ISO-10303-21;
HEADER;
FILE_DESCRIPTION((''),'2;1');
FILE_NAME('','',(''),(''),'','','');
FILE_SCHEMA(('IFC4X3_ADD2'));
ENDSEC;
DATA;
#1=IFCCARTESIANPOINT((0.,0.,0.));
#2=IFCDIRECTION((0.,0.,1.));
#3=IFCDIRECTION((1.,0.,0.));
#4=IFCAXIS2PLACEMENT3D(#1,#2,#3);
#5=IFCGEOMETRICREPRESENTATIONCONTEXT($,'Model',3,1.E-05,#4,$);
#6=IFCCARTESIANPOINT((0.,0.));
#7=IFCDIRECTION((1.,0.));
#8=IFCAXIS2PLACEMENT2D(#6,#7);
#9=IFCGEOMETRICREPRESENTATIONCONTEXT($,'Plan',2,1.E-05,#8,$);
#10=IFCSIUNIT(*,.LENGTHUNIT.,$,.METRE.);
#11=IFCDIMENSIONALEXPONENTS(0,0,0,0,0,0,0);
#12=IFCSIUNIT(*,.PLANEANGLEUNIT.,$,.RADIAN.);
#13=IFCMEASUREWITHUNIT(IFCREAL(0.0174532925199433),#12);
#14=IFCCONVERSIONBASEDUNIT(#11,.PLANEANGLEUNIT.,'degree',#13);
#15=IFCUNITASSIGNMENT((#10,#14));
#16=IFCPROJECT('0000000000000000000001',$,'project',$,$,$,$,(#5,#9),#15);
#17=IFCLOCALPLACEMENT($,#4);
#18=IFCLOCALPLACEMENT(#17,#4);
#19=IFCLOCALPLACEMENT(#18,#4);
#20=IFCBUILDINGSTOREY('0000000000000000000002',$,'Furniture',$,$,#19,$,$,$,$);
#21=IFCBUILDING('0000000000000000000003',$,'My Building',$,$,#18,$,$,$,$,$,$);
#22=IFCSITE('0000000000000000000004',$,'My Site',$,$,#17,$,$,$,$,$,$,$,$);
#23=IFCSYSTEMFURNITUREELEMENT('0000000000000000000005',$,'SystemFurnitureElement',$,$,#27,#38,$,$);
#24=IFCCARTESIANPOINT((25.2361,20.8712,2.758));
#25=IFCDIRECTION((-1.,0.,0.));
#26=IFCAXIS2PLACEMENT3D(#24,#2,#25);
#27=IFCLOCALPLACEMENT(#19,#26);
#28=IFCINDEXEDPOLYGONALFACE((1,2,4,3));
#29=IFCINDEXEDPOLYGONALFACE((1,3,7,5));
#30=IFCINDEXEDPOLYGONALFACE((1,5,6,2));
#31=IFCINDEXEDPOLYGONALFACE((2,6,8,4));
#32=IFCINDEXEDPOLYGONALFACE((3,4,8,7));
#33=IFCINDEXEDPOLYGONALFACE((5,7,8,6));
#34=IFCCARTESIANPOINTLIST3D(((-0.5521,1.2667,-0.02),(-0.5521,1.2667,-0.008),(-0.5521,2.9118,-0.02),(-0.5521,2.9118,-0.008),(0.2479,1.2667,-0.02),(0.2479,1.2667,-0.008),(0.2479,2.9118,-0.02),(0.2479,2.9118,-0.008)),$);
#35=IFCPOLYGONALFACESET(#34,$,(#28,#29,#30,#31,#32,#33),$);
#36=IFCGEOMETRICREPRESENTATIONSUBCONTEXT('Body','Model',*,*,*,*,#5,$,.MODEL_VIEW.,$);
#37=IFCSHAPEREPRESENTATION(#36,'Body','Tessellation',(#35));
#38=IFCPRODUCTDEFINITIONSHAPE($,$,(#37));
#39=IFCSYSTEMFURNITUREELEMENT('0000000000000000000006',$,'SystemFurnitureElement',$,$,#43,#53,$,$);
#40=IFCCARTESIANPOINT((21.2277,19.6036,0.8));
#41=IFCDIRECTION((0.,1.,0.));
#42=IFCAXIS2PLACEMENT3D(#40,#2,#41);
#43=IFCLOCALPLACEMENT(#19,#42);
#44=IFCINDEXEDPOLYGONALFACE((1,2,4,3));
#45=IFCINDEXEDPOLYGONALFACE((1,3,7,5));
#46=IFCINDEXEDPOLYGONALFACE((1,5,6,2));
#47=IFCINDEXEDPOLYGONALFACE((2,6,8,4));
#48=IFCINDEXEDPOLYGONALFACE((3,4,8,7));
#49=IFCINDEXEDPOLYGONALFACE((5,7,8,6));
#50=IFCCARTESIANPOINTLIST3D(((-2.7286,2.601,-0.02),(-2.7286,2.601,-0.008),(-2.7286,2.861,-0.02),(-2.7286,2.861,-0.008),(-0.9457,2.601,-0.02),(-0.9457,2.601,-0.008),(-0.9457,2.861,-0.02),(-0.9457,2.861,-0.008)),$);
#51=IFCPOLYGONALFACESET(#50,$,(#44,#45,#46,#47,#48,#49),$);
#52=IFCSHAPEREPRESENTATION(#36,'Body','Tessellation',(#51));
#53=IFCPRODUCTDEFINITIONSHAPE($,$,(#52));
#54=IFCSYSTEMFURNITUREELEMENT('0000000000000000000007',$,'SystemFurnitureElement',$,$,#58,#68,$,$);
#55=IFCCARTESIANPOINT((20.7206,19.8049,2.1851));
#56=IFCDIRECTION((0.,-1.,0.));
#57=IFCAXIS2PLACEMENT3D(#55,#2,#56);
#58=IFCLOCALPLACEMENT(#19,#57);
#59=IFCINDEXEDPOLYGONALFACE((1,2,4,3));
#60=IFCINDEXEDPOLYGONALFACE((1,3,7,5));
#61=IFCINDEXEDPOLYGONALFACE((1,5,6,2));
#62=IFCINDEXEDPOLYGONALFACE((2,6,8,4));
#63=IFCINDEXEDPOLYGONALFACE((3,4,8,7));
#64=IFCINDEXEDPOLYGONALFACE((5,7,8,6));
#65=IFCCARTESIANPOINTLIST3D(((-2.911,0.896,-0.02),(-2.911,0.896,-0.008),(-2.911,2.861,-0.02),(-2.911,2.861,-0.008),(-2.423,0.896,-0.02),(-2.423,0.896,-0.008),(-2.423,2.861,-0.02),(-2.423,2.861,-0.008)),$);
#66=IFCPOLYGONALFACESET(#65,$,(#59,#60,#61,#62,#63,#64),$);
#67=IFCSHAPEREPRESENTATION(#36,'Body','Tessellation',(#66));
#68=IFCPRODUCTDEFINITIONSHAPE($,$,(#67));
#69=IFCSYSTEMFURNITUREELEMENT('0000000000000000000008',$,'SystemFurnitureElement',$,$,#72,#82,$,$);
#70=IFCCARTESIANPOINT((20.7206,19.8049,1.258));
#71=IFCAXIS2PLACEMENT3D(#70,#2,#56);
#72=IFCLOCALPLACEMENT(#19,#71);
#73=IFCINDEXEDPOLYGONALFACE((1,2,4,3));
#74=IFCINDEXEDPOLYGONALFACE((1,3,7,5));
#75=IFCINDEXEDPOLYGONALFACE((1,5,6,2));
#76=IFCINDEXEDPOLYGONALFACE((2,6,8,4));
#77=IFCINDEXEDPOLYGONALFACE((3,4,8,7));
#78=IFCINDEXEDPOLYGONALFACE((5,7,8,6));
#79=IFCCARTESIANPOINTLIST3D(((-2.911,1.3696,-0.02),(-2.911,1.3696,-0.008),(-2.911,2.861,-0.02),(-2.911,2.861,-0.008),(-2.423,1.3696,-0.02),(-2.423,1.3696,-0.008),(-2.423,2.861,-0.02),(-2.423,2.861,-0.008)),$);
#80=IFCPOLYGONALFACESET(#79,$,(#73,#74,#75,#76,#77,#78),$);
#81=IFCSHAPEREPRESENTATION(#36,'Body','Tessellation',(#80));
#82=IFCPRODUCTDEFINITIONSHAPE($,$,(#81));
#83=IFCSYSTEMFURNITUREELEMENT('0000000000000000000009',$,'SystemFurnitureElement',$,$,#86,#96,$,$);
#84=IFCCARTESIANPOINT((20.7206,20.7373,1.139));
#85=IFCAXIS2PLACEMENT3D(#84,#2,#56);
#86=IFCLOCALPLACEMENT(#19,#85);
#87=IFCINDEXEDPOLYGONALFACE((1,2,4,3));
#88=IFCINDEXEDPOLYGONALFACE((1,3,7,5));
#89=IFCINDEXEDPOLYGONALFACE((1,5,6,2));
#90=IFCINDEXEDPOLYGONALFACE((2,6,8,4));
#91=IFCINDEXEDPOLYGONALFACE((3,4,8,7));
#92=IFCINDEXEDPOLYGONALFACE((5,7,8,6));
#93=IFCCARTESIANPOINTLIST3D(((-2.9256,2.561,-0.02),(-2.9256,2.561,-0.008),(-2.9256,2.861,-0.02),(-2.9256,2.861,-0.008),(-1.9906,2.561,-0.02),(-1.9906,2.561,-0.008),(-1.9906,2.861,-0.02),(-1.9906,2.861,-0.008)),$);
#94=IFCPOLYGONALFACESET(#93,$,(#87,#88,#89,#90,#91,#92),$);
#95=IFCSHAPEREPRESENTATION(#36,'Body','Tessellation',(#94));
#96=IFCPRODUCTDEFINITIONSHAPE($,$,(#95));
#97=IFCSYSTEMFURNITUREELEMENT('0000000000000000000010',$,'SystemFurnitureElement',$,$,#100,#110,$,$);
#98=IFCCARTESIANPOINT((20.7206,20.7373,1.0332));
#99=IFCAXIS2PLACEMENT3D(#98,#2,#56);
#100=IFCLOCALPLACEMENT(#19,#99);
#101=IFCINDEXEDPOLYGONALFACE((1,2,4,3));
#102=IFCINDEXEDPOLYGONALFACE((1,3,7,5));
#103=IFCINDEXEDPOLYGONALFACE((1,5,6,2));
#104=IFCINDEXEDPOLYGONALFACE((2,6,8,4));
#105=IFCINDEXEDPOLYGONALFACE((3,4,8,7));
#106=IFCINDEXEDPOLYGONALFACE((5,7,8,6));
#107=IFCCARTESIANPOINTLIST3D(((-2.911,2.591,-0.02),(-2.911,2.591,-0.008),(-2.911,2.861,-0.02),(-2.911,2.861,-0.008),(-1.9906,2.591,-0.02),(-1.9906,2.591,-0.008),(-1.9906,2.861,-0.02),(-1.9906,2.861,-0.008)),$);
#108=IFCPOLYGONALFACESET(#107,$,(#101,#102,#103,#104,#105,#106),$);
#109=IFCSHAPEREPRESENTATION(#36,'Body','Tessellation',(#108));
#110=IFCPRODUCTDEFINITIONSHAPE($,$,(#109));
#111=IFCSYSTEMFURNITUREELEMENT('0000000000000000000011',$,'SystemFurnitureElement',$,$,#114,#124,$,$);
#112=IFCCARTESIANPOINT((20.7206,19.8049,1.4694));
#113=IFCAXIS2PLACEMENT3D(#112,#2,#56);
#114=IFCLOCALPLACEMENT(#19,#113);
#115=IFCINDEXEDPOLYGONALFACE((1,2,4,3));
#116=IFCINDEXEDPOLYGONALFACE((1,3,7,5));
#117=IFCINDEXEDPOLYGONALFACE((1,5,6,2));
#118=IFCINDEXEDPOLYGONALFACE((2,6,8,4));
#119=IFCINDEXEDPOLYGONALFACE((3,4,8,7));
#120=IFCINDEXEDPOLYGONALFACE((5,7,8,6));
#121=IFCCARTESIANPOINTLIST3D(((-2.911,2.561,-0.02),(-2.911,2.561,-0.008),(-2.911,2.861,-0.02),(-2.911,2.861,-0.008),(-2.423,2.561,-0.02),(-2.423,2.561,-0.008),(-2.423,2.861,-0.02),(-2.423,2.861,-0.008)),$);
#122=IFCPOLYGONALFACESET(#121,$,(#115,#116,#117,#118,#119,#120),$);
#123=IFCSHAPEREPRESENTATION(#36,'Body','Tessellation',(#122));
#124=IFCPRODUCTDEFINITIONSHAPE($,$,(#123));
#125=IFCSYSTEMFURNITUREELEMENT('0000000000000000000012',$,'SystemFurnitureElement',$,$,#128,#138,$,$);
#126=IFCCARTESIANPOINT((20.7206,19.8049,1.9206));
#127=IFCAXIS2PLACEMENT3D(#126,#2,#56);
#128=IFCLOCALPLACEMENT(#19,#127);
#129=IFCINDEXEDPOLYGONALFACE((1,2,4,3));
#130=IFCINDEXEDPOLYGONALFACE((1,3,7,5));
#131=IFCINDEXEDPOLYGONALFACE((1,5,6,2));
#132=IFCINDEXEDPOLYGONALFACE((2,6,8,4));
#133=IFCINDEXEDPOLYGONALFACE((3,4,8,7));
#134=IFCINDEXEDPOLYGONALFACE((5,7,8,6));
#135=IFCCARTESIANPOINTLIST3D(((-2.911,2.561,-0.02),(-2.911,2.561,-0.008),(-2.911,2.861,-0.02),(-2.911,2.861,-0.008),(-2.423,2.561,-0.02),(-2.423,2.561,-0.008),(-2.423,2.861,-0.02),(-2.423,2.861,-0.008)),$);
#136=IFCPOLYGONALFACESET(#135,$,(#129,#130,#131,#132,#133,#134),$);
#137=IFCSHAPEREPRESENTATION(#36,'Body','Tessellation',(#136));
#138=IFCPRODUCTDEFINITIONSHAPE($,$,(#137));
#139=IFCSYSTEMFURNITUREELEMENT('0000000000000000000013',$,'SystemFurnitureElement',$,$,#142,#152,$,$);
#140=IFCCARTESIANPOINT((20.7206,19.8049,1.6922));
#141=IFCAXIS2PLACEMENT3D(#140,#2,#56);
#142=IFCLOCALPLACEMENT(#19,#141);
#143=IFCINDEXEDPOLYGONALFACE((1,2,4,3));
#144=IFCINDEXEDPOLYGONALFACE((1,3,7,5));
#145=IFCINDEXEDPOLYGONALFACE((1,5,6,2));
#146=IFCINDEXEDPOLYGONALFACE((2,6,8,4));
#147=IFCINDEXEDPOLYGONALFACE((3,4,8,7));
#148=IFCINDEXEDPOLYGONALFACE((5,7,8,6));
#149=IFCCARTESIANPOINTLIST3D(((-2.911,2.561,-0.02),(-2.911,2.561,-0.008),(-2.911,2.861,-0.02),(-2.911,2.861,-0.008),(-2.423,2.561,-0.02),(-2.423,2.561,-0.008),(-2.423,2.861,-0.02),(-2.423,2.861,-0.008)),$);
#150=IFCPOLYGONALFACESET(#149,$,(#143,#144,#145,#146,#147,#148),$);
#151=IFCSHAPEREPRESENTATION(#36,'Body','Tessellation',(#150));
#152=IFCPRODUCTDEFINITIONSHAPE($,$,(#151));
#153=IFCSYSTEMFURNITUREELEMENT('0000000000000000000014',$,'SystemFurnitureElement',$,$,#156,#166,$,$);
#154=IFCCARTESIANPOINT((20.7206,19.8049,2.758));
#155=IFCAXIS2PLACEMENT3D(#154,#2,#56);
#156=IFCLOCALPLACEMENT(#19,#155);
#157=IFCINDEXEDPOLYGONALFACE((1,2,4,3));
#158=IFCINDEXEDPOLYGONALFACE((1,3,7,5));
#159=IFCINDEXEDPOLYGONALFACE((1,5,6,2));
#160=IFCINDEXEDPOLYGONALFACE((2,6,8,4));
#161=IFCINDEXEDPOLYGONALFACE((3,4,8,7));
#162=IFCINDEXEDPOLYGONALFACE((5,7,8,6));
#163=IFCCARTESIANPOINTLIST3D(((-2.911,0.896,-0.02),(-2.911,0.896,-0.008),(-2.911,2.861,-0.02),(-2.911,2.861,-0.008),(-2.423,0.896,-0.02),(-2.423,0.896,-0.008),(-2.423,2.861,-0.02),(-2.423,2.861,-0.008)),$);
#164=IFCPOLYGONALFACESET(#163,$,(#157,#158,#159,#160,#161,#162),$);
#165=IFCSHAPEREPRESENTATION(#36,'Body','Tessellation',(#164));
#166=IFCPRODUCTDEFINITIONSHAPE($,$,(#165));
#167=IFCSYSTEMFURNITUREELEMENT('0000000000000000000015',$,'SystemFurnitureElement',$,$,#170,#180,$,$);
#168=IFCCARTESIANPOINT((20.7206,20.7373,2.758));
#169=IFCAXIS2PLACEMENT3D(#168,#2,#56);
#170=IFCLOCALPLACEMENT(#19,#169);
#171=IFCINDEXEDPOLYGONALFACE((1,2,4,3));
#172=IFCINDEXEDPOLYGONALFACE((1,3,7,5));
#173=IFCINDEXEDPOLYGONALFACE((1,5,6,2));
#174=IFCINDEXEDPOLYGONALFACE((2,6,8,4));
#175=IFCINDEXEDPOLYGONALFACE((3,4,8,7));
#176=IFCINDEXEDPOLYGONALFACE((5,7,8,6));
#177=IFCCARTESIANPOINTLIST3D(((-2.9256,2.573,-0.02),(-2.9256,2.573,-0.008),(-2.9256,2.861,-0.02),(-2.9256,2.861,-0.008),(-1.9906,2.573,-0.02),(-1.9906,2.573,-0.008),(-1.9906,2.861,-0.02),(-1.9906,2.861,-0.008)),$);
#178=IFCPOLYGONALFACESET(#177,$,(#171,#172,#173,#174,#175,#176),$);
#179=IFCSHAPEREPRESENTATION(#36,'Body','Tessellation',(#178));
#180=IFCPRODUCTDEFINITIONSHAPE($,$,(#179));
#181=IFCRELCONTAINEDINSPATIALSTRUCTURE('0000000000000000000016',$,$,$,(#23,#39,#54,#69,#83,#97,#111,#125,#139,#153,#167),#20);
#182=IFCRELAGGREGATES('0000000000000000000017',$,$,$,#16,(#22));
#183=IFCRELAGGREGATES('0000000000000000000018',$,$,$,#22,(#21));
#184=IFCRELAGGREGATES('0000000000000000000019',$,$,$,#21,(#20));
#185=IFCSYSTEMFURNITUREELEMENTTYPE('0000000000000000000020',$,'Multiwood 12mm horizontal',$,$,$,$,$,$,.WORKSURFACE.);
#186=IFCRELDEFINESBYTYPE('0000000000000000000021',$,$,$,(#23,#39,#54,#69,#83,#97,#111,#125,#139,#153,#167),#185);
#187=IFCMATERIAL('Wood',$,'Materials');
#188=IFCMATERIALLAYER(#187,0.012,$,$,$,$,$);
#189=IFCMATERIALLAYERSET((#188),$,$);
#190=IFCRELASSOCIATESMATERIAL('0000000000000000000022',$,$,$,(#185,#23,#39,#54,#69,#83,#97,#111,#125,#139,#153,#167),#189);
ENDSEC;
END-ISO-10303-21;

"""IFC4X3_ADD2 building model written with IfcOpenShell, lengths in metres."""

from ifc_helpers import new_model, entity, si_unit, converted_unit, frame, origin_with_axes, origin_2d_with_axis, place, context, subcontext, project, spatial, indexed_curve, outline, extrude, material, layer, layer_set, layer_usage, type_object, element, save


model = new_model("IFC4X3_ADD2")

# Units and contexts
model_context = context("Model", 3, precision=1e-05, world=origin_with_axes())
plan_context = context("Plan", 2, precision=1e-05, world=origin_2d_with_axis())
body_context = subcontext(model_context, "Body", "Model", "MODEL_VIEW")
ifc_project = project(units=[si_unit("LENGTHUNIT", "METRE"), converted_unit("PLANEANGLEUNIT", "degree", entity("IfcReal", 0.0174532925199433), si_unit("PLANEANGLEUNIT", "RADIAN"), dimensions=[0, 0, 0, 0, 0, 0, 0])], contexts=[model_context, plan_context])

# Site, building, storey
site_placement = place(None, origin_with_axes())
site = spatial("IfcSite", under=ifc_project, at=site_placement, Name="My Site")
building_placement = place(site_placement, origin_with_axes())
building = spatial("IfcBuilding", under=site, at=building_placement, Name="My Building")
storey_placement = place(building_placement, origin_with_axes())
storey = spatial("IfcBuildingStorey", under=building, at=storey_placement, Name="Furniture")

# System furniture elements
ifc_material = material(Name="Wood", Category="Materials")
ifc_layer_1 = layer(ifc_material, 0.012)
ifc_layer_set_1 = layer_set([ifc_layer_1])
system_furniture_element_type_1 = type_object("IfcSystemFurnitureElementType", Name="Multiwood 12mm horizontal", PredefinedType="WORKSURFACE", material=ifc_layer_set_1)
ifc_layer_usage_1 = layer_usage(ifc_layer_set_1, "AXIS3", "POSITIVE", -0.02)
system_furniture_element_1_placement = place(storey_placement, frame((25.2361, 20.8712, 2.758), z_axis=(0.0, 0.0, 1.0), x_axis=(-1.0, 0.0, 0.0)))
element("IfcSystemFurnitureElement", 1, at=system_furniture_element_1_placement, inside=storey, type_object=system_furniture_element_type_1, material=ifc_layer_usage_1, Name="SystemFurnitureElement", context=body_context, shape_type="SweptSolid", body=[
    extrude(outline(indexed_curve([(-0.5521, 2.9118), (0.2479, 2.9118), (0.2479, 1.2667), (-0.5521, 1.2667), (-0.5521, 2.9118)])), frame((0.0, 0.0, -0.02), z_axis=(0.0, 0.0, 1.0), x_axis=(1.0, 0.0, 0.0)), (0.0, 0.0, 1.0), 0.012),
])
ifc_layer_usage_2 = layer_usage(ifc_layer_set_1, "AXIS3", "POSITIVE", -0.02)
system_furniture_element_2_placement = place(storey_placement, frame((21.2277, 19.6036, 0.8), z_axis=(0.0, 0.0, 1.0), x_axis=(0.0, 1.0, 0.0)))
element("IfcSystemFurnitureElement", 2, at=system_furniture_element_2_placement, inside=storey, type_object=system_furniture_element_type_1, material=ifc_layer_usage_2, Name="SystemFurnitureElement", context=body_context, shape_type="SweptSolid", body=[
    extrude(outline(indexed_curve([(-0.9457, 2.861), (-0.9457, 2.601), (-2.7286, 2.601), (-2.7286, 2.861), (-0.9457, 2.861)])), frame((0.0, 0.0, -0.02), z_axis=(0.0, 0.0, 1.0), x_axis=(1.0, 0.0, 0.0)), (0.0, 0.0, 1.0), 0.012),
])
ifc_layer_usage_3 = layer_usage(ifc_layer_set_1, "AXIS3", "POSITIVE", -0.02)
system_furniture_element_3_placement = place(storey_placement, frame((20.7206, 19.8049, 2.1851), z_axis=(0.0, 0.0, 1.0), x_axis=(0.0, -1.0, 0.0)))
element("IfcSystemFurnitureElement", 3, at=system_furniture_element_3_placement, inside=storey, type_object=system_furniture_element_type_1, material=ifc_layer_usage_3, Name="SystemFurnitureElement", context=body_context, shape_type="SweptSolid", body=[
    extrude(outline(indexed_curve([(-2.911, 2.861), (-2.911, 0.896), (-2.423, 0.896), (-2.423, 2.861), (-2.911, 2.861)])), frame((0.0, 0.0, -0.02), z_axis=(0.0, 0.0, 1.0), x_axis=(1.0, 0.0, 0.0)), (0.0, 0.0, 1.0), 0.012),
])
ifc_layer_usage_4 = layer_usage(ifc_layer_set_1, "AXIS3", "POSITIVE", -0.02)
system_furniture_element_4_placement = place(storey_placement, frame((20.7206, 19.8049, 1.258), z_axis=(0.0, 0.0, 1.0), x_axis=(0.0, -1.0, 0.0)))
element("IfcSystemFurnitureElement", 4, at=system_furniture_element_4_placement, inside=storey, type_object=system_furniture_element_type_1, material=ifc_layer_usage_4, Name="SystemFurnitureElement", context=body_context, shape_type="SweptSolid", body=[
    extrude(outline(indexed_curve([(-2.423, 2.861), (-2.423, 1.3696), (-2.911, 1.3696), (-2.911, 2.861), (-2.423, 2.861)])), frame((0.0, 0.0, -0.02), z_axis=(0.0, 0.0, 1.0), x_axis=(1.0, 0.0, 0.0)), (0.0, 0.0, 1.0), 0.012),
])
ifc_layer_usage_5 = layer_usage(ifc_layer_set_1, "AXIS3", "POSITIVE", -0.02)
system_furniture_element_5_placement = place(storey_placement, frame((20.7206, 20.7373, 1.139), z_axis=(0.0, 0.0, 1.0), x_axis=(0.0, -1.0, 0.0)))
element("IfcSystemFurnitureElement", 5, at=system_furniture_element_5_placement, inside=storey, type_object=system_furniture_element_type_1, material=ifc_layer_usage_5, Name="SystemFurnitureElement", context=body_context, shape_type="SweptSolid", body=[
    extrude(outline(indexed_curve([(-2.9256, 2.861), (-2.9256, 2.561), (-1.9906, 2.561), (-1.9906, 2.861), (-2.9256, 2.861)])), frame((0.0, 0.0, -0.02), z_axis=(0.0, 0.0, 1.0), x_axis=(1.0, 0.0, 0.0)), (0.0, 0.0, 1.0), 0.012),
])
ifc_layer_usage_6 = layer_usage(ifc_layer_set_1, "AXIS3", "POSITIVE", -0.02)
system_furniture_element_6_placement = place(storey_placement, frame((20.7206, 20.7373, 1.0332), z_axis=(0.0, 0.0, 1.0), x_axis=(0.0, -1.0, 0.0)))
element("IfcSystemFurnitureElement", 6, at=system_furniture_element_6_placement, inside=storey, type_object=system_furniture_element_type_1, material=ifc_layer_usage_6, Name="SystemFurnitureElement", context=body_context, shape_type="SweptSolid", body=[
    extrude(outline(indexed_curve([(-2.911, 2.861), (-2.911, 2.591), (-1.9906, 2.591), (-1.9906, 2.861), (-2.911, 2.861)])), frame((0.0, 0.0, -0.02), z_axis=(0.0, 0.0, 1.0), x_axis=(1.0, 0.0, 0.0)), (0.0, 0.0, 1.0), 0.012),
])
ifc_layer_usage_7 = layer_usage(ifc_layer_set_1, "AXIS3", "POSITIVE", -0.02)
system_furniture_element_7_placement = place(storey_placement, frame((20.7206, 19.8049, 1.4694), z_axis=(0.0, 0.0, 1.0), x_axis=(0.0, -1.0, 0.0)))
element("IfcSystemFurnitureElement", 7, at=system_furniture_element_7_placement, inside=storey, type_object=system_furniture_element_type_1, material=ifc_layer_usage_7, Name="SystemFurnitureElement", context=body_context, shape_type="SweptSolid", body=[
    extrude(outline(indexed_curve([(-2.911, 2.861), (-2.911, 2.561), (-2.423, 2.561), (-2.423, 2.861), (-2.911, 2.861)])), frame((0.0, 0.0, -0.02), z_axis=(0.0, 0.0, 1.0), x_axis=(1.0, 0.0, 0.0)), (0.0, 0.0, 1.0), 0.012),
])
ifc_layer_usage_8 = layer_usage(ifc_layer_set_1, "AXIS3", "POSITIVE", -0.02)
system_furniture_element_8_placement = place(storey_placement, frame((20.7206, 19.8049, 1.9206), z_axis=(0.0, 0.0, 1.0), x_axis=(0.0, -1.0, 0.0)))
element("IfcSystemFurnitureElement", 8, at=system_furniture_element_8_placement, inside=storey, type_object=system_furniture_element_type_1, material=ifc_layer_usage_8, Name="SystemFurnitureElement", context=body_context, shape_type="SweptSolid", body=[
    extrude(outline(indexed_curve([(-2.911, 2.861), (-2.911, 2.561), (-2.423, 2.561), (-2.423, 2.861), (-2.911, 2.861)])), frame((0.0, 0.0, -0.02), z_axis=(0.0, 0.0, 1.0), x_axis=(1.0, 0.0, 0.0)), (0.0, 0.0, 1.0), 0.012),
])
ifc_layer_usage_9 = layer_usage(ifc_layer_set_1, "AXIS3", "POSITIVE", -0.02)
system_furniture_element_9_placement = place(storey_placement, frame((20.7206, 19.8049, 1.6922), z_axis=(0.0, 0.0, 1.0), x_axis=(0.0, -1.0, 0.0)))
element("IfcSystemFurnitureElement", 9, at=system_furniture_element_9_placement, inside=storey, type_object=system_furniture_element_type_1, material=ifc_layer_usage_9, Name="SystemFurnitureElement", context=body_context, shape_type="SweptSolid", body=[
    extrude(outline(indexed_curve([(-2.911, 2.861), (-2.911, 2.561), (-2.423, 2.561), (-2.423, 2.861), (-2.911, 2.861)])), frame((0.0, 0.0, -0.02), z_axis=(0.0, 0.0, 1.0), x_axis=(1.0, 0.0, 0.0)), (0.0, 0.0, 1.0), 0.012),
])
ifc_layer_usage_10 = layer_usage(ifc_layer_set_1, "AXIS3", "POSITIVE", -0.02)
system_furniture_element_10_placement = place(storey_placement, frame((20.7206, 19.8049, 2.758), z_axis=(0.0, 0.0, 1.0), x_axis=(0.0, -1.0, 0.0)))
element("IfcSystemFurnitureElement", 10, at=system_furniture_element_10_placement, inside=storey, type_object=system_furniture_element_type_1, material=ifc_layer_usage_10, Name="SystemFurnitureElement", context=body_context, shape_type="SweptSolid", body=[
    extrude(outline(indexed_curve([(-2.911, 2.861), (-2.911, 0.896), (-2.423, 0.896), (-2.423, 2.861), (-2.911, 2.861)])), frame((0.0, 0.0, -0.02), z_axis=(0.0, 0.0, 1.0), x_axis=(1.0, 0.0, 0.0)), (0.0, 0.0, 1.0), 0.012),
])
ifc_layer_usage_11 = layer_usage(ifc_layer_set_1, "AXIS3", "POSITIVE", -0.02)
system_furniture_element_11_placement = place(storey_placement, frame((20.7206, 20.7373, 2.758), z_axis=(0.0, 0.0, 1.0), x_axis=(0.0, -1.0, 0.0)))
element("IfcSystemFurnitureElement", 11, at=system_furniture_element_11_placement, inside=storey, type_object=system_furniture_element_type_1, material=ifc_layer_usage_11, Name="SystemFurnitureElement", context=body_context, shape_type="SweptSolid", body=[
    extrude(outline(indexed_curve([(-2.9256, 2.861), (-2.9256, 2.573), (-1.9906, 2.573), (-1.9906, 2.861), (-2.9256, 2.861)])), frame((0.0, 0.0, -0.02), z_axis=(0.0, 0.0, 1.0), x_axis=(1.0, 0.0, 0.0)), (0.0, 0.0, 1.0), 0.012),
])

save(model, "model.ifc")
